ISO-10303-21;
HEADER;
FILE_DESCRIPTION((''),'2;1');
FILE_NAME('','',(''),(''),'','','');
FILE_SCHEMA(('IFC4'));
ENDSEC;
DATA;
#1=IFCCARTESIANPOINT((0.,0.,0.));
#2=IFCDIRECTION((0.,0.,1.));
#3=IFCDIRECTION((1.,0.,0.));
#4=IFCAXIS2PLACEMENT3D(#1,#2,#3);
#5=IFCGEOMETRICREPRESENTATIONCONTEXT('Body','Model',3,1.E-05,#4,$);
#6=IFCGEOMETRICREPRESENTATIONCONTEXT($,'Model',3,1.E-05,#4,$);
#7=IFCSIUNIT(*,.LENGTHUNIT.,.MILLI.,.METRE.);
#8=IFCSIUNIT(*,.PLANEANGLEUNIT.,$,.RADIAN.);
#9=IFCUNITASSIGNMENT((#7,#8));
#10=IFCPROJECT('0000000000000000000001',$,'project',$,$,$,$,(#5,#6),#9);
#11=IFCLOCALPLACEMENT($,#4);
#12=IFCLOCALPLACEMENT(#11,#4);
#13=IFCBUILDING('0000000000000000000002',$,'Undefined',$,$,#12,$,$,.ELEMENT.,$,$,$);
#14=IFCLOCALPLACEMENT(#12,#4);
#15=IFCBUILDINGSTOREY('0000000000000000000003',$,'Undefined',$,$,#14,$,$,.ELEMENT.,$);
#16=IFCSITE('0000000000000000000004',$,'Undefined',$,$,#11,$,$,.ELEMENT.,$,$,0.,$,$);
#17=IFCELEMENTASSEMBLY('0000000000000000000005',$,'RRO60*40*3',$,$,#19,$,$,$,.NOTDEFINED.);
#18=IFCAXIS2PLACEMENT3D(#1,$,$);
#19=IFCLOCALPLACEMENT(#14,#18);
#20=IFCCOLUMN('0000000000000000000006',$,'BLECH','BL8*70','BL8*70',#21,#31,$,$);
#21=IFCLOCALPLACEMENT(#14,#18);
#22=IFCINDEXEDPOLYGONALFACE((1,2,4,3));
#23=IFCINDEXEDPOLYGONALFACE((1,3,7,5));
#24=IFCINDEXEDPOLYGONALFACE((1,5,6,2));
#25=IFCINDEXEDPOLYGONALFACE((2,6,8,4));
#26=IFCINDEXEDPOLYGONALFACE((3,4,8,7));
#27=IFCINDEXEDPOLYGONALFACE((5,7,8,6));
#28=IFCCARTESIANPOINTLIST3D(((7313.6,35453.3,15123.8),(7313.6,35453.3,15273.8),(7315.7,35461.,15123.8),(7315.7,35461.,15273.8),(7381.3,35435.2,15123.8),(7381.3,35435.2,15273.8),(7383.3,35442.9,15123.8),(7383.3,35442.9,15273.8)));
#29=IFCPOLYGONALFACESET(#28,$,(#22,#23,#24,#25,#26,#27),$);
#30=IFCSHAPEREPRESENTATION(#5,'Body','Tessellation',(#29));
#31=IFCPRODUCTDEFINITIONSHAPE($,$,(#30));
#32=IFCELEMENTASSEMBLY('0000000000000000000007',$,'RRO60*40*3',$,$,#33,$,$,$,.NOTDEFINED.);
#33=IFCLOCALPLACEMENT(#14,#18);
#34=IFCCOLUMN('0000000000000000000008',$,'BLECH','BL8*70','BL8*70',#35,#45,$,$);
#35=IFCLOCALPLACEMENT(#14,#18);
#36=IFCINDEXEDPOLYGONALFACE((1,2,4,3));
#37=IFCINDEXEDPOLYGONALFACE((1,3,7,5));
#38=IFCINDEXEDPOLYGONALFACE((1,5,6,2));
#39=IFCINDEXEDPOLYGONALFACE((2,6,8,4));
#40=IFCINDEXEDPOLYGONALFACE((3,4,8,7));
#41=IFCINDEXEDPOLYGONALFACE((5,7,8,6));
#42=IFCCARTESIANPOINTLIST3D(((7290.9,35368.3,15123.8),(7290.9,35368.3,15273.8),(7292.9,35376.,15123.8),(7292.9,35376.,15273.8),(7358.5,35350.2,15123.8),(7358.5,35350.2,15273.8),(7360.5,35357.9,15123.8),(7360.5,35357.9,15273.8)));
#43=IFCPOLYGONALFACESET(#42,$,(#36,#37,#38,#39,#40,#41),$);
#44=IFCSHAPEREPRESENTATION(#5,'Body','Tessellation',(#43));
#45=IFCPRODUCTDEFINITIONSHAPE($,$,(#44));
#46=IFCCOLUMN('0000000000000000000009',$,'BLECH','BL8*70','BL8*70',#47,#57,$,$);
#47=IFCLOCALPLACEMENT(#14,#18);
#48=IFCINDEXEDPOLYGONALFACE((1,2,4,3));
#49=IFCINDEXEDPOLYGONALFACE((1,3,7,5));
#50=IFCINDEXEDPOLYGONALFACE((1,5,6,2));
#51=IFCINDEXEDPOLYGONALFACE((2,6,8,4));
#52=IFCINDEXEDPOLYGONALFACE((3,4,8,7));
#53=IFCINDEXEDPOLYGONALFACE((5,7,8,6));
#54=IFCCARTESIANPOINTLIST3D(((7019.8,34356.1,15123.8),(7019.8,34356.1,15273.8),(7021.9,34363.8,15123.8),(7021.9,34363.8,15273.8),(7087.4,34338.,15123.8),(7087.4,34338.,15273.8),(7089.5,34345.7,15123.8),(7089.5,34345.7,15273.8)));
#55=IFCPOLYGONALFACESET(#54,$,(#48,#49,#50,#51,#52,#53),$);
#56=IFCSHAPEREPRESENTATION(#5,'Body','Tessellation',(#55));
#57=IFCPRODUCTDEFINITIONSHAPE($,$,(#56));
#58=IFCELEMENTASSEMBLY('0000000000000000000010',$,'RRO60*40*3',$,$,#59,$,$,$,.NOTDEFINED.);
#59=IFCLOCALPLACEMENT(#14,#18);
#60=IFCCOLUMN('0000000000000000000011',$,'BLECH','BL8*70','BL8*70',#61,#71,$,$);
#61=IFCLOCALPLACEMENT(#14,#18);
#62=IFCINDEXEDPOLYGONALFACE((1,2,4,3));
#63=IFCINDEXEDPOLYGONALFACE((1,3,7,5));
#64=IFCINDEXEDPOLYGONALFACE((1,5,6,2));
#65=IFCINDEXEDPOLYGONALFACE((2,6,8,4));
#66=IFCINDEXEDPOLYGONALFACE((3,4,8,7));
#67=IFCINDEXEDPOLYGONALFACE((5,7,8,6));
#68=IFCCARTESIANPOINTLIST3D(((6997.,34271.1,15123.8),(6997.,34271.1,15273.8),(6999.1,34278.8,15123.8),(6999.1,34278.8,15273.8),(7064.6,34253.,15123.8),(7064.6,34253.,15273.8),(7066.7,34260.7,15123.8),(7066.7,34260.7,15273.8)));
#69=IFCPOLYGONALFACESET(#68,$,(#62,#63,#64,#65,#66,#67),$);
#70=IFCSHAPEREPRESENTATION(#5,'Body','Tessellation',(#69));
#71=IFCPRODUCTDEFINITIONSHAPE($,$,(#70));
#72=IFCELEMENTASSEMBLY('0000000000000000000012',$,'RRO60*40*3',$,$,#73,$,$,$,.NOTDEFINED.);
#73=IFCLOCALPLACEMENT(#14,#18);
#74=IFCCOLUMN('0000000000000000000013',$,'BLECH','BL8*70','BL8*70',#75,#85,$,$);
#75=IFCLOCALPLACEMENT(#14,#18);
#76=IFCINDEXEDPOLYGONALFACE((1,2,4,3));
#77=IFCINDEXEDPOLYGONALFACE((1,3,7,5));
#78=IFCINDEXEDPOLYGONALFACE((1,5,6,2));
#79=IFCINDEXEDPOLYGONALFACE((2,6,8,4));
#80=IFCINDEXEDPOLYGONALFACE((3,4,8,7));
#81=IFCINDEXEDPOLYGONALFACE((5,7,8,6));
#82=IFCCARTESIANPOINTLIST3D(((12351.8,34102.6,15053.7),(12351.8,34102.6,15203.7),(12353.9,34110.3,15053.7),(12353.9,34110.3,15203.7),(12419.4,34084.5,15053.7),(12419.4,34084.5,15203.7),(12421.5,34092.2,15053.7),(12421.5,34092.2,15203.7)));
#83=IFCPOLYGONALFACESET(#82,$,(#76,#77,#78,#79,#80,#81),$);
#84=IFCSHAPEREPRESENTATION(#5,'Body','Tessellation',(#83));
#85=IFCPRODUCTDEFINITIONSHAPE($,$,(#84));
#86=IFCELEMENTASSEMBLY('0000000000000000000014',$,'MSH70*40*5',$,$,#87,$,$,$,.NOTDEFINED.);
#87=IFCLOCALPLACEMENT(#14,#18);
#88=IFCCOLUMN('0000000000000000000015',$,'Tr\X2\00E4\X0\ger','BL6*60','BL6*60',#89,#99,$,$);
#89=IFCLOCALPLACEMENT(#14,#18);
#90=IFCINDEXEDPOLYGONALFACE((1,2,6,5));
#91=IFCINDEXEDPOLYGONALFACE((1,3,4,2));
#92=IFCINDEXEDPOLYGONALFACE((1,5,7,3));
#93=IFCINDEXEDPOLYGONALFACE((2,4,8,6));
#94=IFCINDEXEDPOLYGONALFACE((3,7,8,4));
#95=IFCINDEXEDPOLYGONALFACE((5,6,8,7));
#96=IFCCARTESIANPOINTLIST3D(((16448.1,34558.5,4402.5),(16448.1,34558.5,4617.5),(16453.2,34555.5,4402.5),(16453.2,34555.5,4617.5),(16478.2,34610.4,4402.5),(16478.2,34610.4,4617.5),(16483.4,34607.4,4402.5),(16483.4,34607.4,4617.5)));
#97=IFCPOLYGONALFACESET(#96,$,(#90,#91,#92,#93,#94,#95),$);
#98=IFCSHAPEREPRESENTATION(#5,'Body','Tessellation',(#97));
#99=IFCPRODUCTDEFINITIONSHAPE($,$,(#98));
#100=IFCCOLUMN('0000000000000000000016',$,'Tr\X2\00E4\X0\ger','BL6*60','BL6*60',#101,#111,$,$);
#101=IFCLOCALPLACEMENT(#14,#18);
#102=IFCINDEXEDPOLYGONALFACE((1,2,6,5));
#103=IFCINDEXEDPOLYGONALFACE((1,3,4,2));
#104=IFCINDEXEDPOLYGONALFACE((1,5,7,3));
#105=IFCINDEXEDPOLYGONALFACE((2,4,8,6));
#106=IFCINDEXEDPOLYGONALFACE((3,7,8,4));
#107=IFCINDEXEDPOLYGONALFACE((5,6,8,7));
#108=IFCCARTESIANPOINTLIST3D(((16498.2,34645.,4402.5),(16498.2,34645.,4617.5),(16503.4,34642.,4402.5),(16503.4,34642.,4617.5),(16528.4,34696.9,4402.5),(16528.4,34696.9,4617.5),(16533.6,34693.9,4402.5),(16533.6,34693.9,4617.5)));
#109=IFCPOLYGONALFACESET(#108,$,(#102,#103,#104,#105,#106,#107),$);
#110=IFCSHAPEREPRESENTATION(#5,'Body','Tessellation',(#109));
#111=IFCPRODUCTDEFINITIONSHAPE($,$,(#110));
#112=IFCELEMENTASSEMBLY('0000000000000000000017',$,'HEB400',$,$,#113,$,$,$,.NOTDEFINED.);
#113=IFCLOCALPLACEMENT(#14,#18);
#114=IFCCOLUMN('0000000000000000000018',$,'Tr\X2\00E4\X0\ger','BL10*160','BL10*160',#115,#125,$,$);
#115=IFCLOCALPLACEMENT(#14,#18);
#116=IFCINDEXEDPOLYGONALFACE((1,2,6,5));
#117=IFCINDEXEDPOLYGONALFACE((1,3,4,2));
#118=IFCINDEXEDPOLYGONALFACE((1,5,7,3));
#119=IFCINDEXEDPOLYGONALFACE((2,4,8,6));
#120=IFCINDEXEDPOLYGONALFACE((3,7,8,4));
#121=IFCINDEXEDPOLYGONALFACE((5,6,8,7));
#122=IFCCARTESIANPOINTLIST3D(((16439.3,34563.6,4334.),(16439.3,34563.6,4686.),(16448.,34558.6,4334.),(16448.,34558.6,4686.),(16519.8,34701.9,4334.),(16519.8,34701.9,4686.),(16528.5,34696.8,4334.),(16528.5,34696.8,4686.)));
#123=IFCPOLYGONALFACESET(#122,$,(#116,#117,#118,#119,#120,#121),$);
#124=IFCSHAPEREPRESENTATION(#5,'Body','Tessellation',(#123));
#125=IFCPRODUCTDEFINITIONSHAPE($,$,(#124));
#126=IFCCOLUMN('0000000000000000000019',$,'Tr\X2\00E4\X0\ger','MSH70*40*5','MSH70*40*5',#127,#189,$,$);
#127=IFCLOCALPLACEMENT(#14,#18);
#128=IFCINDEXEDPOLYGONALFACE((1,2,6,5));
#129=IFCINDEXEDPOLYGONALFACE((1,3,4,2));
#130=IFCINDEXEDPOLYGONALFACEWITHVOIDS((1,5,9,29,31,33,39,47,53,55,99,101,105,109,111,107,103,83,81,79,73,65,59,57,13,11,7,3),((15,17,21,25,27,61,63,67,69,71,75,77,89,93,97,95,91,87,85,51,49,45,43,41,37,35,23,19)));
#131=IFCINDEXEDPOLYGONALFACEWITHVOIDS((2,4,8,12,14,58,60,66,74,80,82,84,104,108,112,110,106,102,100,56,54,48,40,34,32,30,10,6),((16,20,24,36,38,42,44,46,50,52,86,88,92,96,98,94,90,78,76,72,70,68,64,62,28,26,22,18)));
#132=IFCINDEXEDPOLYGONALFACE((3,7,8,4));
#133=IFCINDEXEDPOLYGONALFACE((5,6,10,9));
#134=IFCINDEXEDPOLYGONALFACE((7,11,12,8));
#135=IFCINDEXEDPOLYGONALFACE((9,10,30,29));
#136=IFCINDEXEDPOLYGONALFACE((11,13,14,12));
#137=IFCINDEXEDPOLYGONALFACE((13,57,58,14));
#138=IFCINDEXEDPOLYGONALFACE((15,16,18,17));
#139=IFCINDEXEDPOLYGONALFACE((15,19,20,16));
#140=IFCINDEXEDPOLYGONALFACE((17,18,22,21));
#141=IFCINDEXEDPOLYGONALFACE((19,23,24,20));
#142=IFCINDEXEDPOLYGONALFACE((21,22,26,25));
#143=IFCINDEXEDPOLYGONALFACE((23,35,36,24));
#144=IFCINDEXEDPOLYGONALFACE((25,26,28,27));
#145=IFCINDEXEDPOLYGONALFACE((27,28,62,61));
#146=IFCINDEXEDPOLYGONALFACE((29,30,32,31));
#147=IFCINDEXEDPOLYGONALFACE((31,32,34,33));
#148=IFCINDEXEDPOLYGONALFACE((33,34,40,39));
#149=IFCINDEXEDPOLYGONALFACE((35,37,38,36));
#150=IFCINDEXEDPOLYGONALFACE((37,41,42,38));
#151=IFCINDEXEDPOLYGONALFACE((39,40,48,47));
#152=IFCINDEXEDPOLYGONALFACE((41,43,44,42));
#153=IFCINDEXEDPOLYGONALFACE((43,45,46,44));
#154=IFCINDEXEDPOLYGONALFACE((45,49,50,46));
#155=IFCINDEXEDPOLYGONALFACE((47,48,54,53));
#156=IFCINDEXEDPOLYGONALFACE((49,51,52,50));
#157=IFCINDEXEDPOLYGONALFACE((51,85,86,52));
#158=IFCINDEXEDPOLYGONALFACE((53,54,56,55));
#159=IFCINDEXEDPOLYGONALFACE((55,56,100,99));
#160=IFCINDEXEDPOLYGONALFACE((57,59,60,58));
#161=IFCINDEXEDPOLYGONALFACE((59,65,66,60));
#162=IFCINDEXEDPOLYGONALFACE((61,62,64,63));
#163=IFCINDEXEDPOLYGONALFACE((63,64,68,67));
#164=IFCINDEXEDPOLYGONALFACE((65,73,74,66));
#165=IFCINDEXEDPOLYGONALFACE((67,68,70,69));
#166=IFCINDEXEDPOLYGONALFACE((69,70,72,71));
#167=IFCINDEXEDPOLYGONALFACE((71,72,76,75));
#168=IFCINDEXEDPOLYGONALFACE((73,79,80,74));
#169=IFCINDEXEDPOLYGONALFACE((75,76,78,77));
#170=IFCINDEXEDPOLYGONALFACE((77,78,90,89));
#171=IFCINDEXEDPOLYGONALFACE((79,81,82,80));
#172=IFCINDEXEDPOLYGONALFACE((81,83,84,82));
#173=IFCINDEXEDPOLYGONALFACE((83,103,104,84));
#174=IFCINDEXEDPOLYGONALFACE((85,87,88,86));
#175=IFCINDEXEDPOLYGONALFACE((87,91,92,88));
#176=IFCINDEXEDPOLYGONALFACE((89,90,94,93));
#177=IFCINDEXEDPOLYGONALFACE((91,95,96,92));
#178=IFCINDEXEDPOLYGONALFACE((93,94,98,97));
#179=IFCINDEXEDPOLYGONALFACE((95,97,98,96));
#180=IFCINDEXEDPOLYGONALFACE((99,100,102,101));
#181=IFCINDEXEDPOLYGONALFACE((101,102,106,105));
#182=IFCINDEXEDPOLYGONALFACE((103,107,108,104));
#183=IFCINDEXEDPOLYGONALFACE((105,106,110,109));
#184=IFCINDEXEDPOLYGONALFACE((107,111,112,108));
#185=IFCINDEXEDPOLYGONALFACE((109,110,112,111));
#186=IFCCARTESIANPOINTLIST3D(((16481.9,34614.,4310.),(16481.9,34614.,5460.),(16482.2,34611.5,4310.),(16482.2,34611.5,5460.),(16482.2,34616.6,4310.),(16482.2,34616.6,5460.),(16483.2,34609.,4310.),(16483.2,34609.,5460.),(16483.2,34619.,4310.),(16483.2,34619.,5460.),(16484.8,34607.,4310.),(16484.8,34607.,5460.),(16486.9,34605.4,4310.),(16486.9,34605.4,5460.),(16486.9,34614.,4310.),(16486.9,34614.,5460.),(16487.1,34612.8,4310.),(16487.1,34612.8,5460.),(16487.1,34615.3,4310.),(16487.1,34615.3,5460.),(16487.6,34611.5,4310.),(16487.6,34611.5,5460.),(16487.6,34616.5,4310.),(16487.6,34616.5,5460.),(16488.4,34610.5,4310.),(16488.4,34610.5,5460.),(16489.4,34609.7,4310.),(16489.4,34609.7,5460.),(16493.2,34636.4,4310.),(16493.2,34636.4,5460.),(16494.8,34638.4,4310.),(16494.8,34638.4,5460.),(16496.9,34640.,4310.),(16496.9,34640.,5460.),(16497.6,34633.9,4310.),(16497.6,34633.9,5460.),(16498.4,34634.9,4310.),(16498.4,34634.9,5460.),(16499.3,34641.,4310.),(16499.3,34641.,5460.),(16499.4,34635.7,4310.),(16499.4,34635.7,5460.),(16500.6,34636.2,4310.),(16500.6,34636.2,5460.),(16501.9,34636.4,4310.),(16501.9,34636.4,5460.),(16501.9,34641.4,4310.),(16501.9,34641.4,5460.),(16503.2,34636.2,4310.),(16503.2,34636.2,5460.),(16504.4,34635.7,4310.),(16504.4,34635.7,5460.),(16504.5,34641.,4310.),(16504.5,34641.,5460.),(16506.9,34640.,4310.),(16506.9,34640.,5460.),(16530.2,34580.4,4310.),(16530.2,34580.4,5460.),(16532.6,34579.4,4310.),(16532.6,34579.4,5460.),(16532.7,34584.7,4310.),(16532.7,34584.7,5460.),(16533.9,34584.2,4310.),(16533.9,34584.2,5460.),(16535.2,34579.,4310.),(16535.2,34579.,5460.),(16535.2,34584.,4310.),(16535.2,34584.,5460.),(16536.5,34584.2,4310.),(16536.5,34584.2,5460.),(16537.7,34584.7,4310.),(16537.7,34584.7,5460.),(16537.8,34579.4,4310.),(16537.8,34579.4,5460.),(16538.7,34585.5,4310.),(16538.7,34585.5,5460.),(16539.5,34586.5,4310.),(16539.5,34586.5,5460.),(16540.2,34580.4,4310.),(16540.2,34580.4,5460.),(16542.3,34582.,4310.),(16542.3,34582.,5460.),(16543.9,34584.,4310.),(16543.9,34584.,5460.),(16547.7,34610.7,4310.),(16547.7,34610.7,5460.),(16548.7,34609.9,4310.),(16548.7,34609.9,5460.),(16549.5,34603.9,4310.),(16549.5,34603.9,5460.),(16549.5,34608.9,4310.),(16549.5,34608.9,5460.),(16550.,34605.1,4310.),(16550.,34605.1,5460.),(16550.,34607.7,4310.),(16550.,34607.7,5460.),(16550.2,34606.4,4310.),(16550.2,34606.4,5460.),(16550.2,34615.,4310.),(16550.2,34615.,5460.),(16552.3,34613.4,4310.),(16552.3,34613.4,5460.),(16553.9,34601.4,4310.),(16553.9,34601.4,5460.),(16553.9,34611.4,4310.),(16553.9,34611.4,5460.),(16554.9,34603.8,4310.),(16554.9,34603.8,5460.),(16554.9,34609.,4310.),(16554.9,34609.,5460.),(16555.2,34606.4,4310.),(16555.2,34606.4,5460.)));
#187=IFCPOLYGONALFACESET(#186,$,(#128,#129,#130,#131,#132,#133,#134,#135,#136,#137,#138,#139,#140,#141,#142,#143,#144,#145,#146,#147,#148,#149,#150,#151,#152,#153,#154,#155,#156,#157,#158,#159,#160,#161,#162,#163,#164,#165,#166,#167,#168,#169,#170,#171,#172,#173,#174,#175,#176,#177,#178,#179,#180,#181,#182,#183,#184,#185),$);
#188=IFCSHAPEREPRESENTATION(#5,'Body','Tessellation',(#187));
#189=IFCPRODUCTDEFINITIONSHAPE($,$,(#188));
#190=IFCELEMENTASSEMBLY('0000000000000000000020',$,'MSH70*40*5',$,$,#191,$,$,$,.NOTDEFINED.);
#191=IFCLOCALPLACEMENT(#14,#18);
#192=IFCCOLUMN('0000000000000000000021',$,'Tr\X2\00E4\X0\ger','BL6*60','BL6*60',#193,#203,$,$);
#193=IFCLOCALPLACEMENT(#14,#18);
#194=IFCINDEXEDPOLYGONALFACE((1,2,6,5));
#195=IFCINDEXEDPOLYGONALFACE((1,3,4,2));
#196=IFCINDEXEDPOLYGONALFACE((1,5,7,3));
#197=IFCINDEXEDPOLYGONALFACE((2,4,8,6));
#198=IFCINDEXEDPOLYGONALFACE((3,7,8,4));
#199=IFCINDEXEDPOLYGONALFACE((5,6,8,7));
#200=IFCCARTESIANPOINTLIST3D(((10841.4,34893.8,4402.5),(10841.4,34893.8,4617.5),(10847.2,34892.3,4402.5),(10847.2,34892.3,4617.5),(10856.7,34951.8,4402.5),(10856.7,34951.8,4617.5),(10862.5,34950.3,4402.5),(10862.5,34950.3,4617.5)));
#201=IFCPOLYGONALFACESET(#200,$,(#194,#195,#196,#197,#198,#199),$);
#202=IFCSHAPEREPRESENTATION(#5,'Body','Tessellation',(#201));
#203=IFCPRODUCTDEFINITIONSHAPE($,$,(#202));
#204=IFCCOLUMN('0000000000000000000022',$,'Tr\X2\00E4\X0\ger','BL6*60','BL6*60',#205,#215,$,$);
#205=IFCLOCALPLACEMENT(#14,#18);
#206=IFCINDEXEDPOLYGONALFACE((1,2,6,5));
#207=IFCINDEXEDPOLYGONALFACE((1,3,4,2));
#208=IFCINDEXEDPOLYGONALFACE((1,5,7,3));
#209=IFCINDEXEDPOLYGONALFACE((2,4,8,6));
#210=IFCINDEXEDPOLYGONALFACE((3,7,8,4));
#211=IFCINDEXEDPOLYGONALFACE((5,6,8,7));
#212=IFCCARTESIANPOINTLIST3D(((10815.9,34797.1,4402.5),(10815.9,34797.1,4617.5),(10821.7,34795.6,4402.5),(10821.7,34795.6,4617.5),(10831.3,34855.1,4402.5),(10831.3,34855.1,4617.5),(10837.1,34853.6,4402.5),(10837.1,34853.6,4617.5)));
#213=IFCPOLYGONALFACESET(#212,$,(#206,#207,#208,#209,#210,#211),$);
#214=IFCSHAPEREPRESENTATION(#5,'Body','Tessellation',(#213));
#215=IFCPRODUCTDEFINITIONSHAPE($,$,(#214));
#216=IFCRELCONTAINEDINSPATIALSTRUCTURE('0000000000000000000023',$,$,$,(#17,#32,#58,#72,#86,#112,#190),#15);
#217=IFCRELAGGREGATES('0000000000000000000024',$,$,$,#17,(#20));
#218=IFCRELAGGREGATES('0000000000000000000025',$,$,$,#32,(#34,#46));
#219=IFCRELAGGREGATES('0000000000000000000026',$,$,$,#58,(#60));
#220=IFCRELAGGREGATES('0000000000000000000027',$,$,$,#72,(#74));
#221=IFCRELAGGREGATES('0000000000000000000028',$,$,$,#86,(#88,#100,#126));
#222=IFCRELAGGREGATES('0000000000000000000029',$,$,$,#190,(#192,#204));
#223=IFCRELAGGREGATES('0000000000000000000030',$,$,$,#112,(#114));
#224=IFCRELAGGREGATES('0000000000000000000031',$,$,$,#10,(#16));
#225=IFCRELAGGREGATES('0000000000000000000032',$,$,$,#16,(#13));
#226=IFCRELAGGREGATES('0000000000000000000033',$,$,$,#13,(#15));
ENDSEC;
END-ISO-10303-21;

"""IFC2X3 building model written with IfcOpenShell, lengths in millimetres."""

from ifc_helpers import new_model, si_unit, frame, origin_with_axes, origin_2d_with_axis, place, context, project, spatial, rectangle, hollow_rectangle, extrude, element, aggregate, save


model = new_model("IFC2X3")

# Units and contexts
model_context_1 = context("Model", 3, precision=1e-05, world=origin_with_axes(), identifier="Body")
model_context_2 = context("Model", 3, precision=1e-05, world=origin_with_axes())
ifc_project = project(units=[si_unit("LENGTHUNIT", "METRE", prefix="MILLI"), si_unit("PLANEANGLEUNIT", "RADIAN")], contexts=[model_context_1, model_context_2])

# Site, building, storey
site_placement = place(None, origin_with_axes())
site = spatial("IfcSite", under=ifc_project, at=site_placement, Name="Undefined", CompositionType="ELEMENT", RefElevation=0.0)
building_placement = place(site_placement, origin_with_axes())
building = spatial("IfcBuilding", under=site, at=building_placement, Name="Undefined", CompositionType="ELEMENT")
storey_placement = place(building_placement, origin_with_axes())
storey = spatial("IfcBuildingStorey", under=building, at=storey_placement, Name="Undefined", CompositionType="ELEMENT")

# Element assembly, column
assembly_1 = element("IfcElementAssembly", 1, inside=storey, Name="RRO60*40*3", PredefinedType="NOTDEFINED")
column_1_placement = place(storey_placement, frame((7348.5, 35448.1, 15123.8), z_axis=(0.0, 0.0, 1.0), x_axis=(1.0, 0.0, 0.0)))
column_1 = element("IfcColumn", 2, at=column_1_placement, Name="BLECH", Description="BL8*70", ObjectType="BL8*70", context=model_context_1, shape_type="SweptSolid", body=[
    extrude(rectangle(XDim=8.0, YDim=70.0, at=origin_2d_with_axis()), frame((0.0, 0.0, 150.0), z_axis=(0.0, 0.0, -1.0), x_axis=(0.25876, 0.965942, -0.000006)), (0.0, 0.0, 1.0), 150.0),
])
aggregate(assembly_1, [column_1])

# Element assembly, columns
assembly_2 = element("IfcElementAssembly", 3, inside=storey, Name="RRO60*40*3", PredefinedType="NOTDEFINED")
column_2_placement = place(storey_placement, frame((7325.7, 35363.1, 15123.8), z_axis=(0.0, 0.0, 1.0), x_axis=(1.0, 0.0, 0.0)))
column_2 = element("IfcColumn", 4, at=column_2_placement, Name="BLECH", Description="BL8*70", ObjectType="BL8*70", context=model_context_1, shape_type="SweptSolid", body=[
    extrude(rectangle(XDim=8.0, YDim=70.0, at=origin_2d_with_axis()), frame((0.0, 0.0, 150.0), z_axis=(0.0, 0.0, -1.0), x_axis=(-0.258678, -0.965964, 0.000006)), (0.0, 0.0, 1.0), 150.0),
])
column_3_placement = place(storey_placement, frame((7054.6, 34350.9, 15123.8), z_axis=(0.0, 0.0, 1.0), x_axis=(1.0, 0.0, 0.0)))
column_3 = element("IfcColumn", 5, at=column_3_placement, Name="BLECH", Description="BL8*70", ObjectType="BL8*70", context=model_context_1, shape_type="SweptSolid", body=[
    extrude(rectangle(XDim=8.0, YDim=70.0, at=origin_2d_with_axis()), frame((0.0, 0.0, 150.0), z_axis=(0.0, 0.0, -1.0), x_axis=(0.258678, 0.965964, -0.000006)), (0.0, 0.0, 1.0), 150.0),
])
aggregate(assembly_2, [column_2, column_3])

# Element assemblies, columns
assembly_3 = element("IfcElementAssembly", 6, inside=storey, Name="RRO60*40*3", PredefinedType="NOTDEFINED")
column_4_placement = place(storey_placement, frame((7031.9, 34265.9, 15123.8), z_axis=(0.0, 0.0, 1.0), x_axis=(1.0, 0.0, 0.0)))
column_4 = element("IfcColumn", 7, at=column_4_placement, Name="BLECH", Description="BL8*70", ObjectType="BL8*70", context=model_context_1, shape_type="SweptSolid", body=[
    extrude(rectangle(XDim=8.0, YDim=70.0, at=origin_2d_with_axis()), frame((0.0, 0.0, 150.0), z_axis=(0.0, 0.0, -1.0), x_axis=(-0.258678, -0.965964, 0.000006)), (0.0, 0.0, 1.0), 150.0),
])
aggregate(assembly_3, [column_4])
assembly_4 = element("IfcElementAssembly", 8, inside=storey, Name="RRO60*40*3", PredefinedType="NOTDEFINED")
column_5_placement = place(storey_placement, frame((12386.6, 34097.4, 15053.7), z_axis=(0.0, 0.0, 1.0), x_axis=(1.0, 0.0, 0.0)))
column_5 = element("IfcColumn", 9, at=column_5_placement, Name="BLECH", Description="BL8*70", ObjectType="BL8*70", context=model_context_1, shape_type="SweptSolid", body=[
    extrude(rectangle(XDim=8.0, YDim=70.0, at=origin_2d_with_axis()), frame((0.0, 0.0, 150.0), z_axis=(0.0, 0.0, -1.0), x_axis=(-0.258425, -0.966031, 0.000005)), (0.0, 0.0, 1.0), 150.0),
])
aggregate(assembly_4, [column_5])

# Element assembly, columns
assembly_5 = element("IfcElementAssembly", 10, inside=storey, Name="MSH70*40*5", PredefinedType="NOTDEFINED")
column_6_placement = place(storey_placement, frame((16465.7, 34582.9, 4402.5), z_axis=(0.0, 0.0, 1.0), x_axis=(1.0, 0.0, 0.0)))
column_6 = element("IfcColumn", 11, at=column_6_placement, Name="Träger", Description="BL6*60", ObjectType="BL6*60", context=model_context_1, shape_type="SweptSolid", body=[
    extrude(rectangle(XDim=6.0, YDim=60.0, at=origin_2d_with_axis()), frame((0.0, 0.0, 215.0), z_axis=(0.0, 0.0, -1.0), x_axis=(0.864275, -0.50302, 0.0)), (0.0, 0.0, 1.0), 215.0),
])
column_7_placement = place(storey_placement, frame((16515.9, 34669.4, 4402.5), z_axis=(0.0, 0.0, 1.0), x_axis=(1.0, 0.0, 0.0)))
column_7 = element("IfcColumn", 12, at=column_7_placement, Name="Träger", Description="BL6*60", ObjectType="BL6*60", context=model_context_1, shape_type="SweptSolid", body=[
    extrude(rectangle(XDim=6.0, YDim=60.0, at=origin_2d_with_axis()), frame((0.0, 0.0, 215.0), z_axis=(0.0, 0.0, -1.0), x_axis=(0.864275, -0.50302, 0.0)), (0.0, 0.0, 1.0), 215.0),
])

# Element assembly, column
assembly_6 = element("IfcElementAssembly", 13, inside=storey, Name="HEB400", PredefinedType="NOTDEFINED")
column_8_placement = place(storey_placement, frame((16483.9, 34630.2, 4334.0), z_axis=(0.0, 0.0, 1.0), x_axis=(1.0, 0.0, 0.0)))
column_8 = element("IfcColumn", 14, at=column_8_placement, Name="Träger", Description="BL10*160", ObjectType="BL10*160", context=model_context_1, shape_type="SweptSolid", body=[
    extrude(rectangle(XDim=10.0, YDim=160.0, at=origin_2d_with_axis()), frame((0.0, 0.0, 352.0), z_axis=(0.0, 0.0, -1.0), x_axis=(0.864275, -0.50302, 0.0)), (0.0, 0.0, 1.0), 352.0),
])

# Column
column_9_placement = place(storey_placement, frame((16518.5, 34610.2, 4310.0), z_axis=(0.0, 0.0, 1.0), x_axis=(1.0, 0.0, 0.0)))
column_9 = element("IfcColumn", 15, at=column_9_placement, Name="Träger", Description="MSH70*40*5", ObjectType="MSH70*40*5", context=model_context_1, shape_type="SweptSolid", body=[
    extrude(hollow_rectangle(XDim=40.0, YDim=70.0, WallThickness=5.0, InnerFilletRadius=5.0, OuterFilletRadius=10.0, at=origin_2d_with_axis()), frame((0.0, 0.0, 1150.0), z_axis=(0.0, 0.0, -1.0), x_axis=(0.5, 0.866025, 0.0)), (0.0, 0.0, 1.0), 1150.0),
])
aggregate(assembly_5, [column_6, column_7, column_9])

# Element assembly, columns
assembly_7 = element("IfcElementAssembly", 16, inside=storey, Name="MSH70*40*5", PredefinedType="NOTDEFINED")
column_10_placement = place(storey_placement, frame((10852.0, 34922.1, 4402.5), z_axis=(0.0, 0.0, 1.0), x_axis=(1.0, 0.0, 0.0)))
column_10 = element("IfcColumn", 17, at=column_10_placement, Name="Träger", Description="BL6*60", ObjectType="BL6*60", context=model_context_1, shape_type="SweptSolid", body=[
    extrude(rectangle(XDim=6.0, YDim=60.0, at=origin_2d_with_axis()), frame((0.0, 0.0, 215.0), z_axis=(0.0, 0.0, -1.0), x_axis=(-0.9666, 0.256289, 0.0)), (0.0, 0.0, 1.0), 215.0),
])
column_11_placement = place(storey_placement, frame((10826.5, 34825.4, 4402.5), z_axis=(0.0, 0.0, 1.0), x_axis=(1.0, 0.0, 0.0)))
column_11 = element("IfcColumn", 18, at=column_11_placement, Name="Träger", Description="BL6*60", ObjectType="BL6*60", context=model_context_1, shape_type="SweptSolid", body=[
    extrude(rectangle(XDim=6.0, YDim=60.0, at=origin_2d_with_axis()), frame((0.0, 0.0, 215.0), z_axis=(0.0, 0.0, -1.0), x_axis=(-0.9666, 0.256289, 0.0)), (0.0, 0.0, 1.0), 215.0),
])

aggregate(assembly_7, [column_10, column_11])

aggregate(assembly_6, [column_8])

save(model, "model.ifc")
